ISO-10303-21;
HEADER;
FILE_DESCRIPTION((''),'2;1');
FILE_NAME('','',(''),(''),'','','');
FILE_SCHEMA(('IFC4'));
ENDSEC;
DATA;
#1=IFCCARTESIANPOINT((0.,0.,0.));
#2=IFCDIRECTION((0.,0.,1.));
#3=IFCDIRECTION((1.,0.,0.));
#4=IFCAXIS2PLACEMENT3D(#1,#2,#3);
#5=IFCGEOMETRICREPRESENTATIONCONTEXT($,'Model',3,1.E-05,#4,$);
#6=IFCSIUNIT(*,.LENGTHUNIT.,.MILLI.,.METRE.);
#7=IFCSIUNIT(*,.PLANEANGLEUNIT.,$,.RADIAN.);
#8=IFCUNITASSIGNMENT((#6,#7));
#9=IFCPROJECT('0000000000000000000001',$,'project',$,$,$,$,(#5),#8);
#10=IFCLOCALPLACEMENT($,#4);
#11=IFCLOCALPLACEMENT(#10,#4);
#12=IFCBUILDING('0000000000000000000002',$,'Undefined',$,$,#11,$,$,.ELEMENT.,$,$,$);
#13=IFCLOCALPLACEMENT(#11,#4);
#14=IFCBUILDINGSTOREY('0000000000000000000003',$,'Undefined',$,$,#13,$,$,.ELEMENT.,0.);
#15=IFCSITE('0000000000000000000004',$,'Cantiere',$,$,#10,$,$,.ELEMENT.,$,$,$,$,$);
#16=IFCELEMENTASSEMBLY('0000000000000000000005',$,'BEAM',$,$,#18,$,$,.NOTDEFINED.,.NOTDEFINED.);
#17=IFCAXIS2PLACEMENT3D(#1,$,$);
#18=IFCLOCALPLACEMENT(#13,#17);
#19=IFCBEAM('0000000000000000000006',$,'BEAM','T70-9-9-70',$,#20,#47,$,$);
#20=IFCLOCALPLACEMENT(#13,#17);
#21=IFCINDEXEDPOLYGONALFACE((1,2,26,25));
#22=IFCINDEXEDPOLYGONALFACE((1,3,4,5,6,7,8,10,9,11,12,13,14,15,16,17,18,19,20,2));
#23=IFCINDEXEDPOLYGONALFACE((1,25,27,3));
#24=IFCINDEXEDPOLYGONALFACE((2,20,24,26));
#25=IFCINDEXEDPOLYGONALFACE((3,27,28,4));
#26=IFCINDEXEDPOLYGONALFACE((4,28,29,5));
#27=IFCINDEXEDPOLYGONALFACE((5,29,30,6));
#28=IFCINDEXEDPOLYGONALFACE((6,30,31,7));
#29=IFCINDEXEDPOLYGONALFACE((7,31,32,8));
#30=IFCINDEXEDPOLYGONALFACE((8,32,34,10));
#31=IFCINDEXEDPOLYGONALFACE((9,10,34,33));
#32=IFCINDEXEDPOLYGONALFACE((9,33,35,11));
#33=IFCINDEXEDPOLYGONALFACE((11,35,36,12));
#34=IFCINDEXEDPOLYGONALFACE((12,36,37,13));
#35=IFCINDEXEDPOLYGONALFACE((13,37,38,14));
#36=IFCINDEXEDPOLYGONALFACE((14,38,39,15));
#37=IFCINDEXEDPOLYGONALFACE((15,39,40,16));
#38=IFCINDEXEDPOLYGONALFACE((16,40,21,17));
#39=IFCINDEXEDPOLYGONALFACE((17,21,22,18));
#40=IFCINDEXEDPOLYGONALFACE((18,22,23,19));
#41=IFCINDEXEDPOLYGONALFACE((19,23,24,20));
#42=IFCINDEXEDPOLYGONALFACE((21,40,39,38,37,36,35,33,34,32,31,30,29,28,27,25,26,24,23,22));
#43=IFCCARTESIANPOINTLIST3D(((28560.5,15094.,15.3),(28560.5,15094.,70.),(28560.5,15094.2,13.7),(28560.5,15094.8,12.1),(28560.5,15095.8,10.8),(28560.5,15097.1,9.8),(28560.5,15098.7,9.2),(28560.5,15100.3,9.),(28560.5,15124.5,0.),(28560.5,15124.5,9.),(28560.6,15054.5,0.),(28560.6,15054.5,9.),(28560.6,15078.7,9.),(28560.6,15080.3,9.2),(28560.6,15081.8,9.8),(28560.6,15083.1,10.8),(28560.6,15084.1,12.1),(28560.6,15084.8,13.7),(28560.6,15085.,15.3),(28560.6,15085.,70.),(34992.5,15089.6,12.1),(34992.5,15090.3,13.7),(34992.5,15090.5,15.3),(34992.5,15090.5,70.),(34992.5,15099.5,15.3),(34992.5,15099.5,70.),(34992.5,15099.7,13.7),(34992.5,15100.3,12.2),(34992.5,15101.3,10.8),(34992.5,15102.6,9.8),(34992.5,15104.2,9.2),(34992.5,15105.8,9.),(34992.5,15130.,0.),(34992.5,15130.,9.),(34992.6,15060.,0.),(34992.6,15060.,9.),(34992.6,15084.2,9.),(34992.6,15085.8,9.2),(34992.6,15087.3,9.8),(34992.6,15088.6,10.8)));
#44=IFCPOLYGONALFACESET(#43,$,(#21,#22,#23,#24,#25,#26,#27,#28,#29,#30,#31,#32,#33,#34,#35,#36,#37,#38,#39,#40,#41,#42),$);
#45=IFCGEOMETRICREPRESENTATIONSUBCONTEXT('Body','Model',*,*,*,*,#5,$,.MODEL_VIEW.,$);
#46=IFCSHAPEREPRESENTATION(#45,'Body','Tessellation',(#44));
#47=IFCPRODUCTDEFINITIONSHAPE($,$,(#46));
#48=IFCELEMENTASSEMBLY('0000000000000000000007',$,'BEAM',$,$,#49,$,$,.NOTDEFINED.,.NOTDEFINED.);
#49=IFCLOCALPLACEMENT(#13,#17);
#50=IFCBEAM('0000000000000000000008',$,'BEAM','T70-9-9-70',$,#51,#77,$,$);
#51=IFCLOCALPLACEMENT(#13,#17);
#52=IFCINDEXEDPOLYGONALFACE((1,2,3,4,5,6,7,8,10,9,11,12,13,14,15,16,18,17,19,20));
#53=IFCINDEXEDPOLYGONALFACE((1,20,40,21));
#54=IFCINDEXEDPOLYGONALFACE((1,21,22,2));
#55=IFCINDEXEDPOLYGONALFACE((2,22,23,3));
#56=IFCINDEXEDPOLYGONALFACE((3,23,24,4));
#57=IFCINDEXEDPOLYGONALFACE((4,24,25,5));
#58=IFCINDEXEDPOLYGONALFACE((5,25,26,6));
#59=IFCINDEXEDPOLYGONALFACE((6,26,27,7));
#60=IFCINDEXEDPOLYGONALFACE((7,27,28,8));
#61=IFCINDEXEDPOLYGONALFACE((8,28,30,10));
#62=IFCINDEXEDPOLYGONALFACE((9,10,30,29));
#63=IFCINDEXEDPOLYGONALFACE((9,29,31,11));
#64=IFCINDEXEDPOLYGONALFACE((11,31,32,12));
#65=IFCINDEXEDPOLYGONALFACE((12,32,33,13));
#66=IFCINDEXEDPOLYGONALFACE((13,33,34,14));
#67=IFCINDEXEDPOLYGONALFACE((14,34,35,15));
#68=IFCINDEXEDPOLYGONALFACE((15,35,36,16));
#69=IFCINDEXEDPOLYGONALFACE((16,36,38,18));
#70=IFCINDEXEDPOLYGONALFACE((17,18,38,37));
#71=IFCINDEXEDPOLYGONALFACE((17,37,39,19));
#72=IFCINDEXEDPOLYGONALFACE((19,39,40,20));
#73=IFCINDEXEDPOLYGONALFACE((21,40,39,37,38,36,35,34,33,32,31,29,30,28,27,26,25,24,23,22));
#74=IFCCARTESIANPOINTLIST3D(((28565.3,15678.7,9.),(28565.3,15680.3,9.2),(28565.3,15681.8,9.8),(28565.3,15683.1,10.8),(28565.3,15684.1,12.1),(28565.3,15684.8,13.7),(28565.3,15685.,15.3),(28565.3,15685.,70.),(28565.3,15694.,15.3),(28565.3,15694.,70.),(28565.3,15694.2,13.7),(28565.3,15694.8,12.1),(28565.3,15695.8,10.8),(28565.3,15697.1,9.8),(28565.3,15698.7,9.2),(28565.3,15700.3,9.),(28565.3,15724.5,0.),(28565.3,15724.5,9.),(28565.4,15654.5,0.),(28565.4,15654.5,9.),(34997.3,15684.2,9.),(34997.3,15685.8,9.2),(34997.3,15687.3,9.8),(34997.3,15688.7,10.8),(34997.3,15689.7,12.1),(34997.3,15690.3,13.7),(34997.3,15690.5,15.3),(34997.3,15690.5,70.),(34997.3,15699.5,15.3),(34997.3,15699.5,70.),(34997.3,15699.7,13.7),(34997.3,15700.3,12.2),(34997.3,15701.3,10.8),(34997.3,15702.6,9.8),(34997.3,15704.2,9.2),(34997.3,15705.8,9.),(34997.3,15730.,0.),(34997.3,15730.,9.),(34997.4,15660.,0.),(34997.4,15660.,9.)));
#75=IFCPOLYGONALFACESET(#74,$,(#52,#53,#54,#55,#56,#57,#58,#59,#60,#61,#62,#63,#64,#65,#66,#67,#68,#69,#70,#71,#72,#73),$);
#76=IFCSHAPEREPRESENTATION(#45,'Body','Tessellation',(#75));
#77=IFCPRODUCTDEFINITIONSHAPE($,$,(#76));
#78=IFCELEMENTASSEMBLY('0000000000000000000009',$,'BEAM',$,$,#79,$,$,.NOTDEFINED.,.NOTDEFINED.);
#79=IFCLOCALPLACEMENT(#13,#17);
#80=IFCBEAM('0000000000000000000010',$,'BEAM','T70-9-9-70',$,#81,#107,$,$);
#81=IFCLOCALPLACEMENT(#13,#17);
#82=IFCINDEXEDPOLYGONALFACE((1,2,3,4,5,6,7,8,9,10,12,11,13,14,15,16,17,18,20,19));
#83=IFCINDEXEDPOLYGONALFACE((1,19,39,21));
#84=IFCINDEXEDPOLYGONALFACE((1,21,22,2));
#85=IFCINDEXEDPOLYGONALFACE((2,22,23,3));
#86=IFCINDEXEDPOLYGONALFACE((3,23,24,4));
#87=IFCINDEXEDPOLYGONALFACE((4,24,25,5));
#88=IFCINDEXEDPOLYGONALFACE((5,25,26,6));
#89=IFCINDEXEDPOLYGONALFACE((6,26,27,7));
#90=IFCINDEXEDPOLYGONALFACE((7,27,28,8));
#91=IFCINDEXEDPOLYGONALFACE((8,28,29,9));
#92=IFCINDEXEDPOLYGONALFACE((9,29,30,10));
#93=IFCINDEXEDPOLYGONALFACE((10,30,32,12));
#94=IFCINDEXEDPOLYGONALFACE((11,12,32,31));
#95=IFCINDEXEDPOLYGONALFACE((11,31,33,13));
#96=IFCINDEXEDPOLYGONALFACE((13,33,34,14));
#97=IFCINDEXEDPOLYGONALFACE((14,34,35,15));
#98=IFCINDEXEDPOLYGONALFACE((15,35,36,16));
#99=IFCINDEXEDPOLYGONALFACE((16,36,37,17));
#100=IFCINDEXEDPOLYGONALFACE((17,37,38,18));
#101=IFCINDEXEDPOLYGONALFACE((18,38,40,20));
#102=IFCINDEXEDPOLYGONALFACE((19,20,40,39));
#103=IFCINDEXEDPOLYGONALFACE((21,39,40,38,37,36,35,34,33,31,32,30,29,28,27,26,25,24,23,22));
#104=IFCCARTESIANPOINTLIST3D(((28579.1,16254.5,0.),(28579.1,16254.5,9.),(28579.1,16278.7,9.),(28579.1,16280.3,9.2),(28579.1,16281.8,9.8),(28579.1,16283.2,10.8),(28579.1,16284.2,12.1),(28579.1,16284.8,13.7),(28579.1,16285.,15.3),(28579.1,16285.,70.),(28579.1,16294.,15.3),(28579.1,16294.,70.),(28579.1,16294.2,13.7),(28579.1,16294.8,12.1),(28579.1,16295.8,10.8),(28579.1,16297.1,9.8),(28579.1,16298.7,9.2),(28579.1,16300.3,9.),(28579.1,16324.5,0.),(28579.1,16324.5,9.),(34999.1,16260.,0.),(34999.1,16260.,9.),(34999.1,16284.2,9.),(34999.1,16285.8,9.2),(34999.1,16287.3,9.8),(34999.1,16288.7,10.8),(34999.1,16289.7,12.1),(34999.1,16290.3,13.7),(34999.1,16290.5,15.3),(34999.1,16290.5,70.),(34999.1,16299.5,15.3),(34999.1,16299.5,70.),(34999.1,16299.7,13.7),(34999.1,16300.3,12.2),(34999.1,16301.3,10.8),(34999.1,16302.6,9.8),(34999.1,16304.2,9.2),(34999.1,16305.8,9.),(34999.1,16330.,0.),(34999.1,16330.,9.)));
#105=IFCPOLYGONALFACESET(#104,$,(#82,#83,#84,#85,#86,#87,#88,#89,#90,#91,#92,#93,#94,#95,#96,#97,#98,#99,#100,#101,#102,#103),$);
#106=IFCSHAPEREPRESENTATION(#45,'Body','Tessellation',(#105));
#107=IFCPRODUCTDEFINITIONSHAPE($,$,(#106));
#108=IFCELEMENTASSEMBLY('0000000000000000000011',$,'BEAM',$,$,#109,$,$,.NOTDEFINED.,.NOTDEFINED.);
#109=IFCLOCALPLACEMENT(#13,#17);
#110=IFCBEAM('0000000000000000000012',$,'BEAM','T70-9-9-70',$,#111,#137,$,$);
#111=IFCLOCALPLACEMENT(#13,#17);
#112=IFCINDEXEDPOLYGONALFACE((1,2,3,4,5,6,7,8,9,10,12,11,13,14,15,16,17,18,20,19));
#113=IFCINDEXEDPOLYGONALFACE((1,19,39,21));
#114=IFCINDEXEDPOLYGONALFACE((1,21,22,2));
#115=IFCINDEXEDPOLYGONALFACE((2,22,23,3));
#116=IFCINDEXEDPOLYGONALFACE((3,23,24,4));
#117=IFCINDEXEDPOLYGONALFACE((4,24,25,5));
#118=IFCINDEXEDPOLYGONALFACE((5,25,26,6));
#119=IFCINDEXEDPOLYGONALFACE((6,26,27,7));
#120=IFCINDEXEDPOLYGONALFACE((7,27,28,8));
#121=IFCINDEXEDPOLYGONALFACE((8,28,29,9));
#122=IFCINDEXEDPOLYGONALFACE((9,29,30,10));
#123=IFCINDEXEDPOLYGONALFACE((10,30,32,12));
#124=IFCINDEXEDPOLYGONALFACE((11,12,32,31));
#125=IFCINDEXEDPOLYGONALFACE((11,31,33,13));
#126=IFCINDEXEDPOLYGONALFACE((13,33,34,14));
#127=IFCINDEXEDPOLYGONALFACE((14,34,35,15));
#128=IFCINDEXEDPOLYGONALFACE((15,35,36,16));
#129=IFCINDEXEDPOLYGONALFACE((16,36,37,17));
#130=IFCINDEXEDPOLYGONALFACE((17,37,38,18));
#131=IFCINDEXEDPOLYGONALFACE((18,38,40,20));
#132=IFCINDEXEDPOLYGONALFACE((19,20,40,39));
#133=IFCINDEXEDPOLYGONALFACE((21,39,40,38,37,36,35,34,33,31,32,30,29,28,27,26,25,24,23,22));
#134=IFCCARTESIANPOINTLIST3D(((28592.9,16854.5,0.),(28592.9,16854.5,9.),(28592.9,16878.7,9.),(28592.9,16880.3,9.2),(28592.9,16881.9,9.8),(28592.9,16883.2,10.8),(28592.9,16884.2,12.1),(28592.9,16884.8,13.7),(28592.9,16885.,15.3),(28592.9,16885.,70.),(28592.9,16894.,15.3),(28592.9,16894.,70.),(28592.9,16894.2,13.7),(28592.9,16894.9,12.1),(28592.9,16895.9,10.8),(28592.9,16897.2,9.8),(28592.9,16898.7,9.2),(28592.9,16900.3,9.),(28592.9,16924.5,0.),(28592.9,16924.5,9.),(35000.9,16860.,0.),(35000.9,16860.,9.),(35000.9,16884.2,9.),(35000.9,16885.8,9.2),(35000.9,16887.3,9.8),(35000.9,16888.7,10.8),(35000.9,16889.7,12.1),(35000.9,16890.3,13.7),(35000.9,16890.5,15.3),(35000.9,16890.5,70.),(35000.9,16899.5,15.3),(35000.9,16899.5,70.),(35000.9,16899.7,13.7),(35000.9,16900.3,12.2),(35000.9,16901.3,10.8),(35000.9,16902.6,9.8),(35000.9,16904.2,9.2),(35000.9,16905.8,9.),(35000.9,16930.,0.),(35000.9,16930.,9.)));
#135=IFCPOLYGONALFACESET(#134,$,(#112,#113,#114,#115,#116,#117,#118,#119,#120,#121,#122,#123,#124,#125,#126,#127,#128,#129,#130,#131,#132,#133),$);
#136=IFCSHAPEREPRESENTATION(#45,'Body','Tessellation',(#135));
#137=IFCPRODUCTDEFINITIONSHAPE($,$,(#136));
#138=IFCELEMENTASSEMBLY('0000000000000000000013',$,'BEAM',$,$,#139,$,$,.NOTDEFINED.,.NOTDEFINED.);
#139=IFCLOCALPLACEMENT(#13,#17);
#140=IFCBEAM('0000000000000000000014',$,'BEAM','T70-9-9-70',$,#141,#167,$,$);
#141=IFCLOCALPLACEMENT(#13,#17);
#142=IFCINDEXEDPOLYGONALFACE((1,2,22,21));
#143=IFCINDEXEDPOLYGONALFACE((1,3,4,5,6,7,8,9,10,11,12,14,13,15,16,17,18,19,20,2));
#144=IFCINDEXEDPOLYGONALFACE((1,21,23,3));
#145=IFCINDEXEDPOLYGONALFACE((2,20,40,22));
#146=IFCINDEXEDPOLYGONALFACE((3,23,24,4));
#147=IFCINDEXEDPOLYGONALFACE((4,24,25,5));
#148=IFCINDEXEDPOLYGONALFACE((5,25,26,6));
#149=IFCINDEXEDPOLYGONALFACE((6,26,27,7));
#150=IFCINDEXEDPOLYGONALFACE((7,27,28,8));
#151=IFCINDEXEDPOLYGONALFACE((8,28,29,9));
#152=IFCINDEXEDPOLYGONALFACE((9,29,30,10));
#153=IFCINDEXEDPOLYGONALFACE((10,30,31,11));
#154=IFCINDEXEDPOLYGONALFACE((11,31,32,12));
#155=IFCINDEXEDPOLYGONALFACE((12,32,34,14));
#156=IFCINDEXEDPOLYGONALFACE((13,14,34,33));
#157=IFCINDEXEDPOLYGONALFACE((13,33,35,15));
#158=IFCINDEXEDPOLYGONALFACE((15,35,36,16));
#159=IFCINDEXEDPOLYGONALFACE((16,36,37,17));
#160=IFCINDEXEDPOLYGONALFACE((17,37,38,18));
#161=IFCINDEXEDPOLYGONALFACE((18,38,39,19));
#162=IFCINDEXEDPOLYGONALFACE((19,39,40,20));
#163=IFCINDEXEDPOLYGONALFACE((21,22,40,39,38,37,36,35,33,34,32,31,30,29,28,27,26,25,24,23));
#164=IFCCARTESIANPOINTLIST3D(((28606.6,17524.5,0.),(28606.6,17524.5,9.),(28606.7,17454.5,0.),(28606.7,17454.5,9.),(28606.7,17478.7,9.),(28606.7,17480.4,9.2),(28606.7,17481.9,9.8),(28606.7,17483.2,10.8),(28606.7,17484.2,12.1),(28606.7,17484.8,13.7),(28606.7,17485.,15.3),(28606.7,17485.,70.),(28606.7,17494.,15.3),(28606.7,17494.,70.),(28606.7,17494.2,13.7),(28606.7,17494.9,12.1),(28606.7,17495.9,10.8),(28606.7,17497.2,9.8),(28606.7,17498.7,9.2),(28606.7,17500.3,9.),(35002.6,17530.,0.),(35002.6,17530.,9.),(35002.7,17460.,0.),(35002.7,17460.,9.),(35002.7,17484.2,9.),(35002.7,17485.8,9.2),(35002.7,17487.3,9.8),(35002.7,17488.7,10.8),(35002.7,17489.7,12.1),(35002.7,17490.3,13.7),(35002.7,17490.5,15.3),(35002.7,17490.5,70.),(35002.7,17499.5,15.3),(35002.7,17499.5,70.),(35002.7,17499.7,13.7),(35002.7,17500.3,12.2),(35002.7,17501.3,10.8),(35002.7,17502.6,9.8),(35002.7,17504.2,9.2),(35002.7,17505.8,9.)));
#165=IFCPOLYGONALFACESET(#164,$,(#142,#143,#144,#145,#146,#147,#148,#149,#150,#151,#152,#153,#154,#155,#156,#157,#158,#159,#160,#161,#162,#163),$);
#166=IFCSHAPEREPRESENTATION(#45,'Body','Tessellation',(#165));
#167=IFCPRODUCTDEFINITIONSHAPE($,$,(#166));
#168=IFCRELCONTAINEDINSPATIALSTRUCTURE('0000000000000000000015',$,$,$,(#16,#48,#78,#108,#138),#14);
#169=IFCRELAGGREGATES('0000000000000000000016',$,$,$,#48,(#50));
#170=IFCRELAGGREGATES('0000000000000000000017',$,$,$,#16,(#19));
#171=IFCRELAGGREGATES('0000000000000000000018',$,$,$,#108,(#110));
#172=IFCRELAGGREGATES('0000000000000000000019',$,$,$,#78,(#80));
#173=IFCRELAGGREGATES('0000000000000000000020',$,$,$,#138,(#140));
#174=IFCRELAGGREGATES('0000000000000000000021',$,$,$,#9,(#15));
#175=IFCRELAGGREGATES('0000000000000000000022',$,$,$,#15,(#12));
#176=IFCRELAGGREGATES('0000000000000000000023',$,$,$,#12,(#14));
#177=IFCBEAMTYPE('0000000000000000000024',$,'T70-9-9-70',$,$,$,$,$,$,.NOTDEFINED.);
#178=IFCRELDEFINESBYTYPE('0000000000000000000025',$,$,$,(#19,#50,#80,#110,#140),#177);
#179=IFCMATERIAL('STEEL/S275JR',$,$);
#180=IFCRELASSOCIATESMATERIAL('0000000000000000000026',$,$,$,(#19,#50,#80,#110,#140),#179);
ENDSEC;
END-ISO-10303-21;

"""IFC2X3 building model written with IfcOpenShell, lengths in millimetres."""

from ifc_helpers import new_model, si_unit, frame, origin_with_axes, origin_2d_with_axis, place, context, subcontext, project, spatial, t_section, extrude, material, type_object, element, aggregate, save


model = new_model("IFC2X3")

# Units and contexts
model_context = context("Model", 3, precision=1e-05, world=origin_with_axes())
body_context = subcontext(model_context, "Body", "Model", "MODEL_VIEW")
ifc_project = project(units=[si_unit("LENGTHUNIT", "METRE", prefix="MILLI"), si_unit("PLANEANGLEUNIT", "RADIAN")], contexts=[model_context])

# Site, building, storey
site_placement = place(None, origin_with_axes())
site = spatial("IfcSite", under=ifc_project, at=site_placement, Name="Cantiere", CompositionType="ELEMENT")
building_placement = place(site_placement, origin_with_axes())
building = spatial("IfcBuilding", under=site, at=building_placement, Name="Undefined", CompositionType="ELEMENT")
storey_placement = place(building_placement, origin_with_axes())
storey = spatial("IfcBuildingStorey", under=building, at=storey_placement, Name="Undefined", CompositionType="ELEMENT", Elevation=0.0)

# Element assemblies, beams
ifc_material_1 = material(Name="STEEL/S275JR")
assembly_1_placement = place(storey_placement, origin_with_axes())
assembly_1 = element("IfcElementAssembly", 1, at=assembly_1_placement, inside=storey, Name="BEAM", AssemblyPlace="NOTDEFINED", PredefinedType="NOTDEFINED")
beam_type_1 = type_object("IfcBeamType", Name="T70-9-9-70", PredefinedType="NOTDEFINED")
beam_1_placement = place(assembly_1_placement, frame((34992.5, 15095.0, 35.0), z_axis=(0.0, 0.000001, -1.0), x_axis=(-1.0, -0.000856, 0.0)))
beam_1 = element("IfcBeam", 2, at=beam_1_placement, type_object=beam_type_1, material=ifc_material_1, Name="BEAM", Description="T70-9-9-70", context=body_context, shape_type="SweptSolid", body=[
    extrude(t_section(Depth=70.0, FlangeWidth=70.0, WebThickness=9.0, FlangeThickness=9.0, FilletRadius=6.3, at=origin_2d_with_axis()), frame((6432.0, 0.0, 0.0), z_axis=(-1.0, 0.0, 0.0), x_axis=(0.0, -1.0, 0.0)), (0.0, 0.0, 1.0), 6432.0),
])
assembly_2_placement = place(storey_placement, origin_with_axes())
assembly_2 = element("IfcElementAssembly", 3, at=assembly_2_placement, inside=storey, Name="BEAM", AssemblyPlace="NOTDEFINED", PredefinedType="NOTDEFINED")
beam_2_placement = place(assembly_2_placement, frame((34997.3, 15695.0, 35.0), z_axis=(0.0, 0.000001, -1.0), x_axis=(-1.0, -0.000856, 0.0)))
beam_2 = element("IfcBeam", 4, at=beam_2_placement, type_object=beam_type_1, material=ifc_material_1, Name="BEAM", Description="T70-9-9-70", context=body_context, shape_type="SweptSolid", body=[
    extrude(t_section(Depth=70.0, FlangeWidth=70.0, WebThickness=9.0, FlangeThickness=9.0, FilletRadius=6.3, at=origin_2d_with_axis()), frame((6432.0, 0.0, 0.0), z_axis=(-1.0, 0.0, 0.0), x_axis=(0.0, -1.0, 0.0)), (0.0, 0.0, 1.0), 6432.0),
])
assembly_3_placement = place(storey_placement, origin_with_axes())
assembly_3 = element("IfcElementAssembly", 5, at=assembly_3_placement, inside=storey, Name="BEAM", AssemblyPlace="NOTDEFINED", PredefinedType="NOTDEFINED")
beam_3_placement = place(assembly_3_placement, frame((34999.1, 16295.0, 35.0), z_axis=(0.0, 0.000001, -1.0), x_axis=(-1.0, -0.000856, 0.0)))
beam_3 = element("IfcBeam", 6, at=beam_3_placement, type_object=beam_type_1, material=ifc_material_1, Name="BEAM", Description="T70-9-9-70", context=body_context, shape_type="SweptSolid", body=[
    extrude(t_section(Depth=70.0, FlangeWidth=70.0, WebThickness=9.0, FlangeThickness=9.0, FilletRadius=6.3, at=origin_2d_with_axis()), frame((6420.0, 0.0, 0.0), z_axis=(-1.0, 0.0, 0.0), x_axis=(0.0, -1.0, 0.0)), (0.0, 0.0, 1.0), 6420.0),
])
assembly_4_placement = place(storey_placement, origin_with_axes())
assembly_4 = element("IfcElementAssembly", 7, at=assembly_4_placement, inside=storey, Name="BEAM", AssemblyPlace="NOTDEFINED", PredefinedType="NOTDEFINED")
beam_4_placement = place(assembly_4_placement, frame((35000.9, 16895.0, 35.0), z_axis=(0.0, 0.000001, -1.0), x_axis=(-1.0, -0.000856, 0.0)))
beam_4 = element("IfcBeam", 8, at=beam_4_placement, type_object=beam_type_1, material=ifc_material_1, Name="BEAM", Description="T70-9-9-70", context=body_context, shape_type="SweptSolid", body=[
    extrude(t_section(Depth=70.0, FlangeWidth=70.0, WebThickness=9.0, FlangeThickness=9.0, FilletRadius=6.3, at=origin_2d_with_axis()), frame((6408.0, 0.0, 0.0), z_axis=(-1.0, 0.0, 0.0), x_axis=(0.0, -1.0, 0.0)), (0.0, 0.0, 1.0), 6408.0),
])
assembly_5_placement = place(storey_placement, origin_with_axes())
assembly_5 = element("IfcElementAssembly", 9, at=assembly_5_placement, inside=storey, Name="BEAM", AssemblyPlace="NOTDEFINED", PredefinedType="NOTDEFINED")
beam_5_placement = place(assembly_5_placement, frame((35002.7, 17495.0, 35.0), z_axis=(0.0, 0.000001, -1.0), x_axis=(-1.0, -0.000856, 0.0)))
beam_5 = element("IfcBeam", 10, at=beam_5_placement, type_object=beam_type_1, material=ifc_material_1, Name="BEAM", Description="T70-9-9-70", context=body_context, shape_type="SweptSolid", body=[
    extrude(t_section(Depth=70.0, FlangeWidth=70.0, WebThickness=9.0, FlangeThickness=9.0, FilletRadius=6.3, at=origin_2d_with_axis()), frame((6396.0, 0.0, 0.0), z_axis=(-1.0, 0.0, 0.0), x_axis=(0.0, -1.0, 0.0)), (0.0, 0.0, 1.0), 6396.0),
])

aggregate(assembly_2, [beam_2])
aggregate(assembly_1, [beam_1])
aggregate(assembly_4, [beam_4])
aggregate(assembly_3, [beam_3])
aggregate(assembly_5, [beam_5])

save(model, "model.ifc")
